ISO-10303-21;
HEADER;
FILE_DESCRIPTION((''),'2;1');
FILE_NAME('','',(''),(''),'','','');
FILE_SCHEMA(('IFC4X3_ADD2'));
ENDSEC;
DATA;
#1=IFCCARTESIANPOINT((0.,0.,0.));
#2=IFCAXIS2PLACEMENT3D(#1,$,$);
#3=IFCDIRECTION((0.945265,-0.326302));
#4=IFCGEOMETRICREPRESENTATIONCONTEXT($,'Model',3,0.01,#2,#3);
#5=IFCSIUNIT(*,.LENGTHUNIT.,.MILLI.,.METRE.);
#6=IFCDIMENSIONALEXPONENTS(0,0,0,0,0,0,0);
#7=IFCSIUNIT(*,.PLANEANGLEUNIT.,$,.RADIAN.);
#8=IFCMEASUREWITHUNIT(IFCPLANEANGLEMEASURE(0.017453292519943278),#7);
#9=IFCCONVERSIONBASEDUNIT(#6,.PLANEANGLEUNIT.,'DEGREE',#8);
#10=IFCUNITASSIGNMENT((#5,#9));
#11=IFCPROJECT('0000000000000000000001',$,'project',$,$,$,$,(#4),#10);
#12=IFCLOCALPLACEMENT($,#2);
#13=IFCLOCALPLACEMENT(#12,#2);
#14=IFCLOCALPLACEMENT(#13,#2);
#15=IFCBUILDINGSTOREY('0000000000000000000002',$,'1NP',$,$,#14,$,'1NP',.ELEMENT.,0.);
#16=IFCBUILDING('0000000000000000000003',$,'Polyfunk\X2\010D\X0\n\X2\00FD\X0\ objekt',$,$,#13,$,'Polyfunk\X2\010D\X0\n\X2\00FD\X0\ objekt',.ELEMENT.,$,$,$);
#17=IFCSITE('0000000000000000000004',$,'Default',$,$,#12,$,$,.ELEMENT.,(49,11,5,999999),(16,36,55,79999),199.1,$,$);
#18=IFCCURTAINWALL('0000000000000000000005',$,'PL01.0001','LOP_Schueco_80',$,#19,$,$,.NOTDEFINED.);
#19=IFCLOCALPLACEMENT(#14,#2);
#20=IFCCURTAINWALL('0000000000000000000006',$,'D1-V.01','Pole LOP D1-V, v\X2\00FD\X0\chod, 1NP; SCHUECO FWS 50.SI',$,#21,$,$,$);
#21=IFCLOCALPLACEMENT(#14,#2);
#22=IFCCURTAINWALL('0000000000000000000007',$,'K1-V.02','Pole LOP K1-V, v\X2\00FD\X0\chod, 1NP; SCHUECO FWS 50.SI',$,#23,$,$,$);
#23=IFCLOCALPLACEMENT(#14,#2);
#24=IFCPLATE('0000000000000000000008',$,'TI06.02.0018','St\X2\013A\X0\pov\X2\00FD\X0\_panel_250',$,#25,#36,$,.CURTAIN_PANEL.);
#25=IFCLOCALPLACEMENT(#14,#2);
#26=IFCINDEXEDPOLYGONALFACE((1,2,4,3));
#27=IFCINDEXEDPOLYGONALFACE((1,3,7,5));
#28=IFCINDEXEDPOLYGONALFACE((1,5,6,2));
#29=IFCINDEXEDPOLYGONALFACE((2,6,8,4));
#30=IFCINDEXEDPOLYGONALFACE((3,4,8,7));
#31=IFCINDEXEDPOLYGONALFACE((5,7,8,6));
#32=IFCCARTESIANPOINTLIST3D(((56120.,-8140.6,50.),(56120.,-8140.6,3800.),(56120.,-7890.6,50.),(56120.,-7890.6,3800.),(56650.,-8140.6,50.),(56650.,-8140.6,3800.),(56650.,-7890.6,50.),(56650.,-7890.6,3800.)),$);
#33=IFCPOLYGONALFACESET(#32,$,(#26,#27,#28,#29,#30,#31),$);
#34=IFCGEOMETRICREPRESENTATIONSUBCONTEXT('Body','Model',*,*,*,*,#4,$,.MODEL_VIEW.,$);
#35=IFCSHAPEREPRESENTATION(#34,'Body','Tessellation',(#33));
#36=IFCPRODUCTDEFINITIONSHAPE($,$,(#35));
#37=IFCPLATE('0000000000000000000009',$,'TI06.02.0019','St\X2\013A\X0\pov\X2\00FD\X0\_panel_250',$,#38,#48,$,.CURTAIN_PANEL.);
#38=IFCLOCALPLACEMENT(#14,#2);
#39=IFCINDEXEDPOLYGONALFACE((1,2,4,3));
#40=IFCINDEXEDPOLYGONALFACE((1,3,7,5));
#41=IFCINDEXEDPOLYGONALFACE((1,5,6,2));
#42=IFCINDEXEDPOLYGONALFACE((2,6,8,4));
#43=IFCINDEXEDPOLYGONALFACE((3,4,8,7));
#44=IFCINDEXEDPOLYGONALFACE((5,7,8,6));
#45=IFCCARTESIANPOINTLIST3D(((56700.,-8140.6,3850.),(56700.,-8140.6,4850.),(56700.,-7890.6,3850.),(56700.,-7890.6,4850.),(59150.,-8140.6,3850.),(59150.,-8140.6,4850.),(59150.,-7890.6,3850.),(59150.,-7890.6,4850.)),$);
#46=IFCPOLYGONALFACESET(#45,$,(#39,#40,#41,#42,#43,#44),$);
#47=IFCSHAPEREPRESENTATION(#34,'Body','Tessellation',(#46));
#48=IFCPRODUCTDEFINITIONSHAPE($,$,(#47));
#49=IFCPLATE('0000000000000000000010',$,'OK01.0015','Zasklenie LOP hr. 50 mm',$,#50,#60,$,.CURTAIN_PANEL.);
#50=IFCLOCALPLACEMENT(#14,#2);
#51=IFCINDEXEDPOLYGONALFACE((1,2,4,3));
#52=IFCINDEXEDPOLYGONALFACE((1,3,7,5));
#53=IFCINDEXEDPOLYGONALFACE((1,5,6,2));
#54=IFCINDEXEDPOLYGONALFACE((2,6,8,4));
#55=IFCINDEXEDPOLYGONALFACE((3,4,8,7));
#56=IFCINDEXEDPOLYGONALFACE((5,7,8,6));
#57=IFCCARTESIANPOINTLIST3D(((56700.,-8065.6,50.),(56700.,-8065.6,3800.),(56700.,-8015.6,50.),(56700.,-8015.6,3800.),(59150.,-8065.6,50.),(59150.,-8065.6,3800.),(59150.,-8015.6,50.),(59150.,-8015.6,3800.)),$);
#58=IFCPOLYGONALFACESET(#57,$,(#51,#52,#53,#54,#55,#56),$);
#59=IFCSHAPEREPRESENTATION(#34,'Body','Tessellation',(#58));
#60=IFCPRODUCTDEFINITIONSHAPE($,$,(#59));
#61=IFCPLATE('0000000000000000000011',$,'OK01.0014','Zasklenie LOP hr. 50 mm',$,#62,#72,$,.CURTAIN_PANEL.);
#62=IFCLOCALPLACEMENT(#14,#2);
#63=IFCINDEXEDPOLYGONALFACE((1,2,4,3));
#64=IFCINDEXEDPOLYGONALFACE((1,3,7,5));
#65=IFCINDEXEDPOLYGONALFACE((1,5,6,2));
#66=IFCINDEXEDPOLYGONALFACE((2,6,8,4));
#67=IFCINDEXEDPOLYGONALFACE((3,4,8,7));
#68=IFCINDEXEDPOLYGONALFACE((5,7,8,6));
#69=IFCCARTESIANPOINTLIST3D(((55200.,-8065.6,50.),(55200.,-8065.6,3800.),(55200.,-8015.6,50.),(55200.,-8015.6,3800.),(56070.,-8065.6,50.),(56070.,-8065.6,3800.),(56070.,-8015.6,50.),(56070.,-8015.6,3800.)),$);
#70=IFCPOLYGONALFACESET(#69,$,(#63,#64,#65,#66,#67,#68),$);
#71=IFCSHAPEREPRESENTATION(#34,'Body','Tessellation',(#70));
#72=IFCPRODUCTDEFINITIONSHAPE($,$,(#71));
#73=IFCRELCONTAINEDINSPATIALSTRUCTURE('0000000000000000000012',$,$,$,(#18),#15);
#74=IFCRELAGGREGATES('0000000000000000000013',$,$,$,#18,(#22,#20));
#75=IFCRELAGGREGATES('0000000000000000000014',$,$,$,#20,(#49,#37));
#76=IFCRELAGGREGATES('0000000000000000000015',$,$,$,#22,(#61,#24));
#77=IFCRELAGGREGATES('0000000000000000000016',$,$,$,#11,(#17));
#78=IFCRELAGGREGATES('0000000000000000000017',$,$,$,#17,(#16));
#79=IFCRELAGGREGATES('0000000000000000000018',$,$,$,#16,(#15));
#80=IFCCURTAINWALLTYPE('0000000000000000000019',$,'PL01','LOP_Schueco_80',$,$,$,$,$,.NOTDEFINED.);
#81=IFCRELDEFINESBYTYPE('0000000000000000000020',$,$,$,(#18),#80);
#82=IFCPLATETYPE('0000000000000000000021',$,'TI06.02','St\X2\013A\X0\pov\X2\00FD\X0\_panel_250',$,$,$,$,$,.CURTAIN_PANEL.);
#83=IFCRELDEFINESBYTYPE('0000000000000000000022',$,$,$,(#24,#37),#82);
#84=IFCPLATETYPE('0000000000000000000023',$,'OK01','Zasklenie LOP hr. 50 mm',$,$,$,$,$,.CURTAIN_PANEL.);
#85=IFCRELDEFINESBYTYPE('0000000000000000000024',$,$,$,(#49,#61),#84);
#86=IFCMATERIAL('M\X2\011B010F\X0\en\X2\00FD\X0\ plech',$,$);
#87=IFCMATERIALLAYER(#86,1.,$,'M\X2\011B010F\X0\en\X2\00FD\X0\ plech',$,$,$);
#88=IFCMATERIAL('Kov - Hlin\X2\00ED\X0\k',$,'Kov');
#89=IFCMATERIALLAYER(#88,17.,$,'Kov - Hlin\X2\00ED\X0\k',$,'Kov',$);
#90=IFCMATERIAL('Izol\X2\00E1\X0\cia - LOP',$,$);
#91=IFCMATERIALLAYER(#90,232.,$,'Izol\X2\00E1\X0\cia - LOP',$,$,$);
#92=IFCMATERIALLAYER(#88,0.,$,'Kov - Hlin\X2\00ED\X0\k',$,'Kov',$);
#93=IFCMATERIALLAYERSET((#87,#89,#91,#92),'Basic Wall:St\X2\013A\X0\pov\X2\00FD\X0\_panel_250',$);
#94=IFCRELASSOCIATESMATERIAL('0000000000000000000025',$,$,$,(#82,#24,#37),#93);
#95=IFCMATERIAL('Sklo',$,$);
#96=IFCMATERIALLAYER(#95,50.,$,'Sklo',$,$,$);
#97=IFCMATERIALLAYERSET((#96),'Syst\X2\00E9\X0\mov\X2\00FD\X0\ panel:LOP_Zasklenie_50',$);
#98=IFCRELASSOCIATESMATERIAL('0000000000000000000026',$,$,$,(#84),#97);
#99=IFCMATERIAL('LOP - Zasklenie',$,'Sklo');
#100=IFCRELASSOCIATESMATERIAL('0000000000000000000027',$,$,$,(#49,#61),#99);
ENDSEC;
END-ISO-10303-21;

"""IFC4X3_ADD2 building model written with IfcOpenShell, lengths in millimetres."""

from ifc_helpers import new_model, entity, si_unit, converted_unit, direction, frame, frame_2d, origin, origin_2d_with_axis, place, context, subcontext, project, spatial, rectangle, extrude, source, transform, mapped, material, layer, layer_set, layer_usage, type_object, type_shapes, element, aggregate, save


model = new_model("IFC4X3_ADD2")

# Units and contexts
model_context = context("Model", 3, precision=0.01, world=origin(), true_north=direction((0.945265, -0.326302)))
body_context = subcontext(model_context, "Body", "Model", "MODEL_VIEW")
ifc_project = project(units=[si_unit("LENGTHUNIT", "METRE", prefix="MILLI"), converted_unit("PLANEANGLEUNIT", "DEGREE", entity("IfcPlaneAngleMeasure", 0.017453292519943278), si_unit("PLANEANGLEUNIT", "RADIAN"), dimensions=[0, 0, 0, 0, 0, 0, 0])], contexts=[model_context])

# Site, building, storey
site_placement = place(None, origin())
site = spatial("IfcSite", under=ifc_project, at=site_placement, Name="Default", CompositionType="ELEMENT", RefLatitude=(49, 11, 5, 999999), RefLongitude=(16, 36, 55, 79999), RefElevation=199.1)
building_placement = place(site_placement, origin())
building = spatial("IfcBuilding", under=site, at=building_placement, Name="Polyfunkčný objekt", LongName="Polyfunkčný objekt", CompositionType="ELEMENT")
storey_placement = place(building_placement, origin())
storey = spatial("IfcBuildingStorey", under=building, at=storey_placement, Name="1NP", LongName="1NP", CompositionType="ELEMENT", Elevation=0.0)

# Curtain walls, plates
curtain_wall_type = type_object("IfcCurtainWallType", Name="PL01", Description="LOP_Schueco_80", PredefinedType="NOTDEFINED")
curtain_wall_1_placement = place(storey_placement, origin())
curtain_wall_1 = element("IfcCurtainWall", 1, at=curtain_wall_1_placement, inside=storey, type_object=curtain_wall_type, Name="PL01.0001", Description="LOP_Schueco_80", PredefinedType="NOTDEFINED")
curtain_wall_2 = element("IfcCurtainWall", 2, Name="D1-V.01", Description="Pole LOP D1-V, východ, 1NP; SCHUECO FWS 50.SI")
curtain_wall_3 = element("IfcCurtainWall", 3, Name="K1-V.02", Description="Pole LOP K1-V, východ, 1NP; SCHUECO FWS 50.SI")
aggregate(curtain_wall_1, [curtain_wall_3, curtain_wall_2])
ifc_material_1 = material(Name="Měďený plech")
ifc_layer_1 = layer(ifc_material_1, 1.0, Name="Měďený plech")
ifc_material_2 = material(Name="Kov - Hliník", Category="Kov")
ifc_layer_2 = layer(ifc_material_2, 17.0, Name="Kov - Hliník", Category="Kov")
ifc_material_3 = material(Name="Izolácia - LOP")
ifc_layer_3 = layer(ifc_material_3, 232.0, Name="Izolácia - LOP")
ifc_layer_4 = layer(ifc_material_2, 0.0, Name="Kov - Hliník", Category="Kov")
ifc_layer_set_1 = layer_set([ifc_layer_1, ifc_layer_2, ifc_layer_3, ifc_layer_4], Name="Basic Wall:Stĺpový_panel_250")
ifc_layer_usage_1 = layer_usage(ifc_layer_set_1, "AXIS2", "POSITIVE", -125.0)
plate_type_1 = type_object("IfcPlateType", Name="TI06.02", Description="Stĺpový_panel_250", PredefinedType="CURTAIN_PANEL", material=ifc_layer_set_1)
plate_1_placement = place(storey_placement, frame((56120.0, -8015.6, 50.0)))
plate_1 = element("IfcPlate", 4, at=plate_1_placement, type_object=plate_type_1, material=ifc_layer_usage_1, Name="TI06.02.0018", Description="Stĺpový_panel_250", PredefinedType="CURTAIN_PANEL", context=body_context, shape_type="SweptSolid", body=[
    extrude(rectangle(XDim=250.0, YDim=530.0, at=frame_2d((0.0, 0.0), x_axis=(1.0, 0.0))), frame((265.0, 0.0, 0.0), z_axis=(0.0, 0.0, 1.0), x_axis=(0.0, 1.0, 0.0)), (0.0, 0.0, 1.0), 3750.0),
])
ifc_layer_usage_2 = layer_usage(ifc_layer_set_1, "AXIS2", "POSITIVE", -125.0)
plate_2_placement = place(storey_placement, frame((56700.0, -8015.6, 3850.0)))
plate_2 = element("IfcPlate", 5, at=plate_2_placement, type_object=plate_type_1, material=ifc_layer_usage_2, Name="TI06.02.0019", Description="Stĺpový_panel_250", PredefinedType="CURTAIN_PANEL", context=body_context, shape_type="SweptSolid", body=[
    extrude(rectangle(XDim=250.0, YDim=2450.0, at=origin_2d_with_axis()), frame((1225.0, 0.0, 0.0), z_axis=(0.0, 0.0, 1.0), x_axis=(0.0, 1.0, 0.0)), (0.0, 0.0, 1.0), 1000.0),
])
ifc_material_4 = material(Name="LOP - Zasklenie", Category="Sklo")
ifc_material_5 = material(Name="Sklo")
ifc_layer_5 = layer(ifc_material_5, 50.0, Name="Sklo")
ifc_layer_set_2 = layer_set([ifc_layer_5], Name="Systémový panel:LOP_Zasklenie_50")
plate_type_2 = type_object("IfcPlateType", Name="OK01", Description="Zasklenie LOP hr. 50 mm", PredefinedType="CURTAIN_PANEL", material=ifc_layer_set_2)
shared_shape_1 = source(origin(), body_context, "Body", "SweptSolid", [
    extrude(rectangle(XDim=3750.0, YDim=2450.0, at=frame_2d((-331.2, 0.0), x_axis=(1.0, 0.0))), frame((0.0, -50.0, 2206.2), z_axis=(0.0, 1.0, 0.0), x_axis=(0.0, 0.0, 1.0)), (0.0, 0.0, 1.0), 50.0),
])
plate_3_placement = place(curtain_wall_1_placement, frame((57925.0, -8015.6, 50.0)))
plate_3 = element("IfcPlate", 6, at=plate_3_placement, type_object=plate_type_2, material=ifc_material_4, Name="OK01.0015", Description="Zasklenie LOP hr. 50 mm", PredefinedType="CURTAIN_PANEL", context=body_context, shape_type="MappedRepresentation", body=[
    mapped(shared_shape_1, transform((0.0, 0.0, 0.0), scale=1.0)),
])
aggregate(curtain_wall_2, [plate_3, plate_2])
shared_shape_2 = source(origin(), body_context, "Body", "SweptSolid", [
    extrude(rectangle(XDim=3750.0, YDim=870.0, at=frame_2d((-331.2, 0.0), x_axis=(1.0, 0.0))), frame((0.0, -50.0, 2206.2), z_axis=(0.0, 1.0, 0.0), x_axis=(0.0, 0.0, 1.0)), (0.0, 0.0, 1.0), 50.0),
])
type_shapes(plate_type_2, [shared_shape_1, shared_shape_2])
plate_4_placement = place(curtain_wall_1_placement, frame((55635.0, -8015.6, 50.0)))
plate_4 = element("IfcPlate", 7, at=plate_4_placement, type_object=plate_type_2, material=ifc_material_4, Name="OK01.0014", Description="Zasklenie LOP hr. 50 mm", PredefinedType="CURTAIN_PANEL", context=body_context, shape_type="MappedRepresentation", body=[
    mapped(shared_shape_2, transform((0.0, 0.0, 0.0), scale=1.0)),
])
aggregate(curtain_wall_3, [plate_4, plate_1])

save(model, "model.ifc")
